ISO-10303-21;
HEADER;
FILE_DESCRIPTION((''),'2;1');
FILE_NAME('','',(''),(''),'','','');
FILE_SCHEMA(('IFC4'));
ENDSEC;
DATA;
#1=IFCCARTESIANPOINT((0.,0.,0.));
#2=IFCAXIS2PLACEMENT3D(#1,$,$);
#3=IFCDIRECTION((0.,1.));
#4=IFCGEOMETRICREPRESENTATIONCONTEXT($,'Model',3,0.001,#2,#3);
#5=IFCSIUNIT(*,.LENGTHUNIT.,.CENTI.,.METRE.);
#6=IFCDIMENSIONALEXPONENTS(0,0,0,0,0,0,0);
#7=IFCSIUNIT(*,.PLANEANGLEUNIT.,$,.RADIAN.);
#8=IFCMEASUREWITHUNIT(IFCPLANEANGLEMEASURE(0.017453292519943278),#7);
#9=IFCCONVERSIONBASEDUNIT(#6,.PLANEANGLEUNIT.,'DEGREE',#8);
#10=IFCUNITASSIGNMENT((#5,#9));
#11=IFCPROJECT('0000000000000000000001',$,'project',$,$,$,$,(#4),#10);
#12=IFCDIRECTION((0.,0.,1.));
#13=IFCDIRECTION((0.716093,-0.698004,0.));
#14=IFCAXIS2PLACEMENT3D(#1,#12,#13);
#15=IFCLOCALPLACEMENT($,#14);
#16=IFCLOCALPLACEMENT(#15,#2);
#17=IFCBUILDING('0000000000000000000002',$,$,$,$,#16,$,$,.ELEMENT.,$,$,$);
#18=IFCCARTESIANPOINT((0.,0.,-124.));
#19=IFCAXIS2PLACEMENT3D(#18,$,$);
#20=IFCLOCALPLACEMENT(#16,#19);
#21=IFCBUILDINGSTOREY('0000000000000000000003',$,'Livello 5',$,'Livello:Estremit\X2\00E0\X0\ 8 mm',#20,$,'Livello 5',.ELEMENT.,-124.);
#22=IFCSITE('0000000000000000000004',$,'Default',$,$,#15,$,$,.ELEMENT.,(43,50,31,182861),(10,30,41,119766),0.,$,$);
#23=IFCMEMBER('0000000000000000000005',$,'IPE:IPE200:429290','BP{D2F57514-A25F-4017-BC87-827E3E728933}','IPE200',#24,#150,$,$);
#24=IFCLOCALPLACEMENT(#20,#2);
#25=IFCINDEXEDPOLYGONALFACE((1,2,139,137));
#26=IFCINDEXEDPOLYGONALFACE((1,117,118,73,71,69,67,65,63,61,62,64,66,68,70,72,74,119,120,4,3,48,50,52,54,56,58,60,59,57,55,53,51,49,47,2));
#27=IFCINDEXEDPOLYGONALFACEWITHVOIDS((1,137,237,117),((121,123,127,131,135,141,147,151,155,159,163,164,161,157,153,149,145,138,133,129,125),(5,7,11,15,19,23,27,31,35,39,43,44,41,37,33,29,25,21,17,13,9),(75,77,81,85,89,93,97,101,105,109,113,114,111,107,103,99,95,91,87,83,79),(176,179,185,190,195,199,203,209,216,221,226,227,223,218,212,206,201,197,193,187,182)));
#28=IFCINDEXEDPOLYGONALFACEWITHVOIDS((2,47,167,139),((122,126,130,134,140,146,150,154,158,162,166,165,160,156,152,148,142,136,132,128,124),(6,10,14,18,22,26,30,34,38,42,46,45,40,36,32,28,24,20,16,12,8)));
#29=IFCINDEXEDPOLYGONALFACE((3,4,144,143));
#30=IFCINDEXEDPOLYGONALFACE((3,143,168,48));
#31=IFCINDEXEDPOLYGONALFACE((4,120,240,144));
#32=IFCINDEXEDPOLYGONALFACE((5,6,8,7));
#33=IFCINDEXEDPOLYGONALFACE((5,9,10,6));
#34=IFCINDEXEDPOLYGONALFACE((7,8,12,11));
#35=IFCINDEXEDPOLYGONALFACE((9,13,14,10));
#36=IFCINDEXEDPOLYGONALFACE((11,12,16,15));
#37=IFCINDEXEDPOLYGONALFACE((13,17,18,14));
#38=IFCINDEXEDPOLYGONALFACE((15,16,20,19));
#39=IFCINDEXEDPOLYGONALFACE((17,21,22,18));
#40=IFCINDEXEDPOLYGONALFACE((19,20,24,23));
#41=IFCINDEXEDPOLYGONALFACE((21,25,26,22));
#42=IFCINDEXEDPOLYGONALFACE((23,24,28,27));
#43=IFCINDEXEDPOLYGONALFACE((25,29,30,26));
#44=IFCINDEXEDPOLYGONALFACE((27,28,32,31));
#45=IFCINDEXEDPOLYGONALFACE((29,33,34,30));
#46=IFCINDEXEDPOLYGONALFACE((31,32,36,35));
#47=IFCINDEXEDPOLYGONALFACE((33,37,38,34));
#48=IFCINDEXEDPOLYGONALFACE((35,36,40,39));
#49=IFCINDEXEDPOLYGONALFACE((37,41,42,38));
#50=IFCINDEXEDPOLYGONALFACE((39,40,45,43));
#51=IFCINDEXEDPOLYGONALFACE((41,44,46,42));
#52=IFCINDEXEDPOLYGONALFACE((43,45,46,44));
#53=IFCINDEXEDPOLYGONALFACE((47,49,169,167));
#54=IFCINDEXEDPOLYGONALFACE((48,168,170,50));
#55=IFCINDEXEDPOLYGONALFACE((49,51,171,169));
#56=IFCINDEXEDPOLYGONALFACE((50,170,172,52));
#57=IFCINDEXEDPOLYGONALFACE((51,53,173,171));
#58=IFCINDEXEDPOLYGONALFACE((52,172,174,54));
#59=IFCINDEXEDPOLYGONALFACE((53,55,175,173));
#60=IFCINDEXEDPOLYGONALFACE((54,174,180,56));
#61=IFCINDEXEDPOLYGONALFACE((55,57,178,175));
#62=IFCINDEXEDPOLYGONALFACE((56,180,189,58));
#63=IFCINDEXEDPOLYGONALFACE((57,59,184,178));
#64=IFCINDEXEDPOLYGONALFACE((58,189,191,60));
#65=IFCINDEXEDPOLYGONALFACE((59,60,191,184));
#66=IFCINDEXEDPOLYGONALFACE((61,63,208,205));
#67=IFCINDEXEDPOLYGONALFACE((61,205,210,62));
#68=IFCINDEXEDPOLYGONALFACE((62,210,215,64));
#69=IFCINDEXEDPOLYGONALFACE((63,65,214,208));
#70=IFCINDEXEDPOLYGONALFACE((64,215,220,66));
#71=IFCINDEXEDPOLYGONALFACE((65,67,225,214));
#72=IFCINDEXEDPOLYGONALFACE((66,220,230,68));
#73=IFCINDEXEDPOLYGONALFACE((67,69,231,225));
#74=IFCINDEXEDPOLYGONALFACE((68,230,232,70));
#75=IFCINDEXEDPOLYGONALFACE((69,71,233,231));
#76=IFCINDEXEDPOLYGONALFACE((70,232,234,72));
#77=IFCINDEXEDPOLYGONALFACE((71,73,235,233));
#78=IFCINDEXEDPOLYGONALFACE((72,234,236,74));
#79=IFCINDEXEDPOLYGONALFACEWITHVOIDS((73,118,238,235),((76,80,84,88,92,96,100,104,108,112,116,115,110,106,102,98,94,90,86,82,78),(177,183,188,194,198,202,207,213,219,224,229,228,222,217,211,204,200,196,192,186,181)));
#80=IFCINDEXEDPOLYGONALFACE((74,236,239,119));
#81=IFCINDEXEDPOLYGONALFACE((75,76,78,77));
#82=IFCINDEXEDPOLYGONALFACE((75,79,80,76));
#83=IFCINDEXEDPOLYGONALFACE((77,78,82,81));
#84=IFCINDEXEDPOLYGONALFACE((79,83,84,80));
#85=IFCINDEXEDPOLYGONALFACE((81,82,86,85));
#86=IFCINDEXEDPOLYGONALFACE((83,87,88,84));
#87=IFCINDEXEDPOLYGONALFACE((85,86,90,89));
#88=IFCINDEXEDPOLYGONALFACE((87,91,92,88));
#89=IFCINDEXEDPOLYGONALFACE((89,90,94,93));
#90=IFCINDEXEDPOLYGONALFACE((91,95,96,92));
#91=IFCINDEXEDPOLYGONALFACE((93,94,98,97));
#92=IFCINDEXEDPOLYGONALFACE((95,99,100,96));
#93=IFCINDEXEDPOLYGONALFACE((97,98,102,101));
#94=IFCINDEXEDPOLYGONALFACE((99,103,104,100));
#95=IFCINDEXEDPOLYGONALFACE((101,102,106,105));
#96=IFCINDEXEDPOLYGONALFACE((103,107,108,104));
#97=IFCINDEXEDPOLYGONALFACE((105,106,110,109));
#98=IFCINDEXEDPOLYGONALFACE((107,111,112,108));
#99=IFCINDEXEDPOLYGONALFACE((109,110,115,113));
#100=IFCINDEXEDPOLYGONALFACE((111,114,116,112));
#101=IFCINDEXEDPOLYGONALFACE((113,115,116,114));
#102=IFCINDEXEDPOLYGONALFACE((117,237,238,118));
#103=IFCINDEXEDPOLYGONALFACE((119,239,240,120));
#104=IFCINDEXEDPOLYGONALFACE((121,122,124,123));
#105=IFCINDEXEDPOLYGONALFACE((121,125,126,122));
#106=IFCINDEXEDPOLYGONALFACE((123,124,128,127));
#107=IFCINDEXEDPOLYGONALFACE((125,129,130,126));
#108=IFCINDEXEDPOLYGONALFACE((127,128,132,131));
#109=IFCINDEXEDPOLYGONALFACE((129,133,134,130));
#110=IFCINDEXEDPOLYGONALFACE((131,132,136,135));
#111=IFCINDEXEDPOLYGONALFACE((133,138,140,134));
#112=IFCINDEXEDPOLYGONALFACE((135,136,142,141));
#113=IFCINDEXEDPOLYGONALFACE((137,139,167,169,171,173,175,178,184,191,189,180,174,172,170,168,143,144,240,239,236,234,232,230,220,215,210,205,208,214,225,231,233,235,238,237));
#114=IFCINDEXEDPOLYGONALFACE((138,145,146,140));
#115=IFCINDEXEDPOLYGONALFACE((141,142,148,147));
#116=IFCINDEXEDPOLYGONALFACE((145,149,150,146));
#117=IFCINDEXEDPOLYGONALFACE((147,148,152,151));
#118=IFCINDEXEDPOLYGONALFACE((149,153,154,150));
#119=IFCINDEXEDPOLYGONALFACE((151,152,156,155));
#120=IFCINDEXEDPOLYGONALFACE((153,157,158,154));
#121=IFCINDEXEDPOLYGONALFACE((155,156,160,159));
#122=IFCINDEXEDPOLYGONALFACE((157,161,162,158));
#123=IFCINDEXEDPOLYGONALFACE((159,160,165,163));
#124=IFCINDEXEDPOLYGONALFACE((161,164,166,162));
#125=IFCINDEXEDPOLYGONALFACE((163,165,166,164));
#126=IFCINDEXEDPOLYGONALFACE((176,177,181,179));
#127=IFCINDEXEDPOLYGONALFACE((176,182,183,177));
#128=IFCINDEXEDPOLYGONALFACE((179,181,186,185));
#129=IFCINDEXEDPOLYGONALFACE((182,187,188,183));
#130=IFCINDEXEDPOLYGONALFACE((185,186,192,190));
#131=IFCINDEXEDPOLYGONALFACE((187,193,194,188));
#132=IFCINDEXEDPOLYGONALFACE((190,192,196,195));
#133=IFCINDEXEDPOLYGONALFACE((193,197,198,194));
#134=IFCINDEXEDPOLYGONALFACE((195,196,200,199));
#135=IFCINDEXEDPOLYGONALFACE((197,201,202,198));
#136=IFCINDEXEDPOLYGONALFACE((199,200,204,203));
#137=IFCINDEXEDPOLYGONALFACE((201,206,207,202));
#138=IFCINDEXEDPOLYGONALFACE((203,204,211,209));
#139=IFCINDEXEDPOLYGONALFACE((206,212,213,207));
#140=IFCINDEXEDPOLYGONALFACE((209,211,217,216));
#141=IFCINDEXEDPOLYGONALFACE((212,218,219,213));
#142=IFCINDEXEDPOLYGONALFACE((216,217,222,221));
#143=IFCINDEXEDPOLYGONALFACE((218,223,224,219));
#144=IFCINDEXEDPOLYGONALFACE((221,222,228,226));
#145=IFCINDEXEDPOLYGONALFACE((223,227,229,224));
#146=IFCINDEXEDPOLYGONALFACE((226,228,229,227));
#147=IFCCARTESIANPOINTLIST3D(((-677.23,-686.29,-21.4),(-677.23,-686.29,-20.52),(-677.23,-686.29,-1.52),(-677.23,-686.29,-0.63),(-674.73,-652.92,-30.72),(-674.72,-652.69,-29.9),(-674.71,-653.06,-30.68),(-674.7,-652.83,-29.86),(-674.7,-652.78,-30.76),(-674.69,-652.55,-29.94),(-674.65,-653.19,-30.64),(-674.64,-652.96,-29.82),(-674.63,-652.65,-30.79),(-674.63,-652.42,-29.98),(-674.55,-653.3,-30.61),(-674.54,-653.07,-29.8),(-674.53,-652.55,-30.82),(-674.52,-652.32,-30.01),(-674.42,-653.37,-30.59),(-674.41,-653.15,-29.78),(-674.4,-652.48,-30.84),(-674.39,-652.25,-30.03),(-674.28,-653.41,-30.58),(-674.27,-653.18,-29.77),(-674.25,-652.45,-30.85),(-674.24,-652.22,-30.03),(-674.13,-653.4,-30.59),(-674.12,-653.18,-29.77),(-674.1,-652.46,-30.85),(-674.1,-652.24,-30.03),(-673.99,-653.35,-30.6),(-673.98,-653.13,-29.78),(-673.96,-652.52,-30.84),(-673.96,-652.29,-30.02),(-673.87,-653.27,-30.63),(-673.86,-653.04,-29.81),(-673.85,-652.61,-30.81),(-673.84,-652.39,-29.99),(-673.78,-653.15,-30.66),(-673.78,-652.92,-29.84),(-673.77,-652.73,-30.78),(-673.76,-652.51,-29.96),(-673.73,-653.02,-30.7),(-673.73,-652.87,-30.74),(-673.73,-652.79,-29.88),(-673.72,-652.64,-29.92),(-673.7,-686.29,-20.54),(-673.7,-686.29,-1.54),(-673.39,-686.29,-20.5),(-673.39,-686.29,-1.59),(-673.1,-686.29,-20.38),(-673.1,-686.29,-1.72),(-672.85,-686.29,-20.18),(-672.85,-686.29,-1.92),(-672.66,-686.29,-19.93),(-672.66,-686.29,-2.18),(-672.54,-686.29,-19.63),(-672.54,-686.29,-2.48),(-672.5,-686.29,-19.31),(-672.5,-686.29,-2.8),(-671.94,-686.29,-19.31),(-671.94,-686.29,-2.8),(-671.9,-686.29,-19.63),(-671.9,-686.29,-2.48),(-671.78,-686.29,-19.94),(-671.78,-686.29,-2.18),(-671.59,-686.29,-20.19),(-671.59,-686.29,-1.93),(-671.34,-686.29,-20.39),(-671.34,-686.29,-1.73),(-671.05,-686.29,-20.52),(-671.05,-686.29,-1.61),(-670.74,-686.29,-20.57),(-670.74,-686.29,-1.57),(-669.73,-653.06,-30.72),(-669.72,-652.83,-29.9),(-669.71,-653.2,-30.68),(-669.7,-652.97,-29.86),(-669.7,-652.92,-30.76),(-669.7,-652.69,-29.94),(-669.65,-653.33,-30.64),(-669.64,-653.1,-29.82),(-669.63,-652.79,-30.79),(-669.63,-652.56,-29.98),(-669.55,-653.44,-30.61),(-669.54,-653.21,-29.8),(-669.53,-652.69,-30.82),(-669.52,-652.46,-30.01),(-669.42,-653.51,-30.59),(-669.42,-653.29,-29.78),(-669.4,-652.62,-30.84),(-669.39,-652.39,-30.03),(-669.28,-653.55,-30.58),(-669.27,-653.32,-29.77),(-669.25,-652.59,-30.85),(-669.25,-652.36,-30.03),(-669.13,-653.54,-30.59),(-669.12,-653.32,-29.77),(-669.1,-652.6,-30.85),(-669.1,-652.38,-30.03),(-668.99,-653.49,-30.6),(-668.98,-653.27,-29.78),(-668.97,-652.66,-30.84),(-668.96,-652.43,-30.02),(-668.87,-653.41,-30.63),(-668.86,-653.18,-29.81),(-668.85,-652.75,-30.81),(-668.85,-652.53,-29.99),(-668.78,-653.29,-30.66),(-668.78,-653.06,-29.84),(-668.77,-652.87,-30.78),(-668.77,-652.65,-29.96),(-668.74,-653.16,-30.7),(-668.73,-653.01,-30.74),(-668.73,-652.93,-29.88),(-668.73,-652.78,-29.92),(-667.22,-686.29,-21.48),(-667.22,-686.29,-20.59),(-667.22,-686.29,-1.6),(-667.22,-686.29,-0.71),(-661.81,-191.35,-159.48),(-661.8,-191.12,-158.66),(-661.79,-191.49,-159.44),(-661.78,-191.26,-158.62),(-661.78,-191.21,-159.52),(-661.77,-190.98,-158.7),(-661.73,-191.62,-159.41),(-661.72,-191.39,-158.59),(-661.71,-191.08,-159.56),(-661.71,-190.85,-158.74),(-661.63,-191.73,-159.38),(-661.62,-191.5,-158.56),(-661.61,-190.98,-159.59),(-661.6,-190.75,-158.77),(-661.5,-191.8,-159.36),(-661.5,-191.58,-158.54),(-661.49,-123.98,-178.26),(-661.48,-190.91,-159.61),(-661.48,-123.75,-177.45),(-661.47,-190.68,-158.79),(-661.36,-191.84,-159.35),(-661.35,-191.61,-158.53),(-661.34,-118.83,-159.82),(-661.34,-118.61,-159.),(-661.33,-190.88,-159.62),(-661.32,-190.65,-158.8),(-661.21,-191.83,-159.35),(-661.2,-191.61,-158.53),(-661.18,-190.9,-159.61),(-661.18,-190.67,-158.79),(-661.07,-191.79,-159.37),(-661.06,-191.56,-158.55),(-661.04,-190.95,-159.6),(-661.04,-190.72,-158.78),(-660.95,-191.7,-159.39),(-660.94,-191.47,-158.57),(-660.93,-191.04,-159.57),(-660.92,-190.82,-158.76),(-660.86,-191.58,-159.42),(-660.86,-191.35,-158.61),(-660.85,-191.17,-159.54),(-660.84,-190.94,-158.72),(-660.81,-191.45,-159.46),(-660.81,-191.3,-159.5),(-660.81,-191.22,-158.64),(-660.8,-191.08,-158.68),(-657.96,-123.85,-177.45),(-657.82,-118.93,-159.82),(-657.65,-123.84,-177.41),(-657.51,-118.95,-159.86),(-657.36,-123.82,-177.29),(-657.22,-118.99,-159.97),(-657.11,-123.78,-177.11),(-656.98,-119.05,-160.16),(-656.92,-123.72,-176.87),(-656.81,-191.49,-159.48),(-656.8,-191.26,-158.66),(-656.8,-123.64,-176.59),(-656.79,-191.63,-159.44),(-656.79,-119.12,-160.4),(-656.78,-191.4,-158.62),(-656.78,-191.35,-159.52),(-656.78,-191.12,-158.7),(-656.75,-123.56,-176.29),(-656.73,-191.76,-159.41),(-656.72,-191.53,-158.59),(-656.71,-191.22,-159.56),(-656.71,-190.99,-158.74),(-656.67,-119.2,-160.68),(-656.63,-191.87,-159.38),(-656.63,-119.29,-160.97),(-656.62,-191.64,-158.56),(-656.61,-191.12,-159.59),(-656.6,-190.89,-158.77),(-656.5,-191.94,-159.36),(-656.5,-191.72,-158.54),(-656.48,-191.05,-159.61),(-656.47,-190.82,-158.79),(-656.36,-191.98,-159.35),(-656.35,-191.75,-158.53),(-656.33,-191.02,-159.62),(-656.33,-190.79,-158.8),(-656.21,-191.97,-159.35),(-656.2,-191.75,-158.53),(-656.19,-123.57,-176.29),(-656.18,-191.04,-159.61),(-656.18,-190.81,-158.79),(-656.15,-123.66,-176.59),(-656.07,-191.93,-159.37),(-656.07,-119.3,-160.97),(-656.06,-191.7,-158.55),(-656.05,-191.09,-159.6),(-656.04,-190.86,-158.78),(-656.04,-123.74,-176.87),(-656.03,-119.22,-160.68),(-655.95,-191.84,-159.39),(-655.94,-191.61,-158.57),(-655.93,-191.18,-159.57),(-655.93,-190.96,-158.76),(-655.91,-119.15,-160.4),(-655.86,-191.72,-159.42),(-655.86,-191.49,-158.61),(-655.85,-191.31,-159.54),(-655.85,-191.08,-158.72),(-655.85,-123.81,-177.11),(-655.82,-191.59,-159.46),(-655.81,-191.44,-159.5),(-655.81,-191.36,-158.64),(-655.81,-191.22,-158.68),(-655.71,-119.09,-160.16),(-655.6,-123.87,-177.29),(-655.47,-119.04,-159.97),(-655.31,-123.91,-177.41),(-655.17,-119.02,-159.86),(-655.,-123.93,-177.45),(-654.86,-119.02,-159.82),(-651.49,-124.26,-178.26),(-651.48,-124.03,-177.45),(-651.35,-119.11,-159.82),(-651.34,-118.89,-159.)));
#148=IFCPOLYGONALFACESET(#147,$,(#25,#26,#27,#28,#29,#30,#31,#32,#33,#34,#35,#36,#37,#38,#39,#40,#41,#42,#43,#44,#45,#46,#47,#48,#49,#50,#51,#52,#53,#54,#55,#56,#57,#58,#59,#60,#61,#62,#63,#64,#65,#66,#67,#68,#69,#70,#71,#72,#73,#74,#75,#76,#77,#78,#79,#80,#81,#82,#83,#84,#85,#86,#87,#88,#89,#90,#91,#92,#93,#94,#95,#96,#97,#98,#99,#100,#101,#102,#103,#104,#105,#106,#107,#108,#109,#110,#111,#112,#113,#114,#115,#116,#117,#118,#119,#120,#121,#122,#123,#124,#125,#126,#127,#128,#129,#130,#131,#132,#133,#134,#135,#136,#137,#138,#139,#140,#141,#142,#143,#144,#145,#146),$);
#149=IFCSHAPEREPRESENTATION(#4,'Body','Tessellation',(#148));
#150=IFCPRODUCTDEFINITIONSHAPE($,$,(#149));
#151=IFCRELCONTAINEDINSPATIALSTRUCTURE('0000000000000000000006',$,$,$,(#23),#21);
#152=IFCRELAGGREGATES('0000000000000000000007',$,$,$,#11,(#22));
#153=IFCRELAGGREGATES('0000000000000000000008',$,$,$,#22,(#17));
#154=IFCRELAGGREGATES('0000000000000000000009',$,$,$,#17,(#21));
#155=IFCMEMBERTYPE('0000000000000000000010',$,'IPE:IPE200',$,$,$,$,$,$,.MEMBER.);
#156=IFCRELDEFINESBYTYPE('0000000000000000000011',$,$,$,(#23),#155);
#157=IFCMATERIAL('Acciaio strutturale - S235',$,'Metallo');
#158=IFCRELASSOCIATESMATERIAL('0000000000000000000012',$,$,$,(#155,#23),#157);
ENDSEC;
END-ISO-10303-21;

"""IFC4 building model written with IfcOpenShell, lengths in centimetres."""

from ifc_helpers import new_model, entity, si_unit, converted_unit, direction, frame, frame_2d, origin, origin_2d, place, context, project, spatial, circle, i_section, extrude, clip, halfspace, material, type_object, element, save


model = new_model("IFC4")

# Units and contexts
model_context = context("Model", 3, precision=0.001, world=origin(), true_north=direction((0.0, 1.0)))
ifc_project = project(units=[si_unit("LENGTHUNIT", "METRE", prefix="CENTI"), converted_unit("PLANEANGLEUNIT", "DEGREE", entity("IfcPlaneAngleMeasure", 0.017453292519943278), si_unit("PLANEANGLEUNIT", "RADIAN"), dimensions=[0, 0, 0, 0, 0, 0, 0])], contexts=[model_context])

# Site, building, storey
site_placement = place(None, frame((0.0, 0.0, 0.0), z_axis=(0.0, 0.0, 1.0), x_axis=(0.716093, -0.698004, 0.0)))
site = spatial("IfcSite", under=ifc_project, at=site_placement, Name="Default", CompositionType="ELEMENT", RefLatitude=(43, 50, 31, 182861), RefLongitude=(10, 30, 41, 119766), RefElevation=0.0)
building_placement = place(site_placement, origin())
building = spatial("IfcBuilding", under=site, at=building_placement, CompositionType="ELEMENT")
storey_placement = place(building_placement, frame((0.0, 0.0, -124.0)))
storey = spatial("IfcBuildingStorey", under=building, at=storey_placement, Name="Livello 5", ObjectType="Livello:Estremità 8 mm", LongName="Livello 5", CompositionType="ELEMENT", Elevation=-124.0)

# Shared definitions
ifc_material_1 = material(Name="Acciaio strutturale - S235", Category="Metallo")

# Member, openings
member_type_1 = type_object("IfcMemberType", Name="IPE:IPE200", PredefinedType="MEMBER", material=ifc_material_1)
member_1_placement = place(storey_placement, frame((-673.34, -726.15, 0.07), z_axis=(-0.026952, -0.962871, 0.268612), x_axis=(0.999608, -0.02798, 0.0)))
member_1 = element("IfcMember", 1, at=member_1_placement, inside=storey, type_object=member_type_1, material=ifc_material_1, Name="IPE:IPE200:429290", Description="BP{D2F57514-A25F-4017-BC87-827E3E728933}", ObjectType="IPE200", context=model_context, shape_type="Clipping", body=[
    clip(extrude(i_section(OverallWidth=10.0, OverallDepth=20.0, WebThickness=0.56, FlangeThickness=0.85, FilletRadius=1.2, at=origin_2d()), origin(), (0.0, 0.0, -1.0), 628.04), halfspace(frame((671.96, 135.14, -23.24), z_axis=(-0.02798, 0.268507, -0.962871), x_axis=(-0.999608, -0.007516, 0.026952)), True)),
])
opening_1_placement = place(member_1_placement, frame((1.56, -9.1, -78.75), z_axis=(0.0, 1.0, 0.0), x_axis=(-1.0, 0.0, 0.0)))
element("IfcOpeningElement", 2, at=opening_1_placement, cuts=member_1, ObjectType="Opening", context=model_context, shape_type="SweptSolid", body=[
    extrude(circle(Radius=0.5, at=frame_2d((-0.5, 0.0), x_axis=(1.0, 0.0))), origin(), (0.0, 0.0, -1.0), 0.95),
])
opening_2_placement = place(member_1_placement, frame((-3.44, -9.1, -78.75), z_axis=(0.0, 1.0, 0.0), x_axis=(-1.0, 0.0, 0.0)))
element("IfcOpeningElement", 3, at=opening_2_placement, cuts=member_1, ObjectType="Opening", context=model_context, shape_type="SweptSolid", body=[
    extrude(circle(Radius=0.5, at=frame_2d((-0.5, 0.0), x_axis=(1.0, 0.0))), origin(), (0.0, 0.0, -1.0), 0.95),
])
opening_3_placement = place(member_1_placement, frame((1.56, -9.1, -558.11), z_axis=(0.0, 1.0, 0.0), x_axis=(-1.0, 0.0, 0.0)))
element("IfcOpeningElement", 4, at=opening_3_placement, cuts=member_1, ObjectType="Opening", context=model_context, shape_type="SweptSolid", body=[
    extrude(circle(Radius=0.5, at=frame_2d((-0.5, 0.0), x_axis=(1.0, 0.0))), origin(), (0.0, 0.0, -1.0), 0.95),
])
opening_4_placement = place(member_1_placement, frame((-3.44, -9.1, -558.11), z_axis=(0.0, 1.0, 0.0), x_axis=(-1.0, 0.0, 0.0)))
element("IfcOpeningElement", 5, at=opening_4_placement, cuts=member_1, ObjectType="Opening", context=model_context, shape_type="SweptSolid", body=[
    extrude(circle(Radius=0.5, at=frame_2d((-0.5, 0.0), x_axis=(1.0, 0.0))), origin(), (0.0, 0.0, -1.0), 0.95),
])

save(model, "model.ifc")
